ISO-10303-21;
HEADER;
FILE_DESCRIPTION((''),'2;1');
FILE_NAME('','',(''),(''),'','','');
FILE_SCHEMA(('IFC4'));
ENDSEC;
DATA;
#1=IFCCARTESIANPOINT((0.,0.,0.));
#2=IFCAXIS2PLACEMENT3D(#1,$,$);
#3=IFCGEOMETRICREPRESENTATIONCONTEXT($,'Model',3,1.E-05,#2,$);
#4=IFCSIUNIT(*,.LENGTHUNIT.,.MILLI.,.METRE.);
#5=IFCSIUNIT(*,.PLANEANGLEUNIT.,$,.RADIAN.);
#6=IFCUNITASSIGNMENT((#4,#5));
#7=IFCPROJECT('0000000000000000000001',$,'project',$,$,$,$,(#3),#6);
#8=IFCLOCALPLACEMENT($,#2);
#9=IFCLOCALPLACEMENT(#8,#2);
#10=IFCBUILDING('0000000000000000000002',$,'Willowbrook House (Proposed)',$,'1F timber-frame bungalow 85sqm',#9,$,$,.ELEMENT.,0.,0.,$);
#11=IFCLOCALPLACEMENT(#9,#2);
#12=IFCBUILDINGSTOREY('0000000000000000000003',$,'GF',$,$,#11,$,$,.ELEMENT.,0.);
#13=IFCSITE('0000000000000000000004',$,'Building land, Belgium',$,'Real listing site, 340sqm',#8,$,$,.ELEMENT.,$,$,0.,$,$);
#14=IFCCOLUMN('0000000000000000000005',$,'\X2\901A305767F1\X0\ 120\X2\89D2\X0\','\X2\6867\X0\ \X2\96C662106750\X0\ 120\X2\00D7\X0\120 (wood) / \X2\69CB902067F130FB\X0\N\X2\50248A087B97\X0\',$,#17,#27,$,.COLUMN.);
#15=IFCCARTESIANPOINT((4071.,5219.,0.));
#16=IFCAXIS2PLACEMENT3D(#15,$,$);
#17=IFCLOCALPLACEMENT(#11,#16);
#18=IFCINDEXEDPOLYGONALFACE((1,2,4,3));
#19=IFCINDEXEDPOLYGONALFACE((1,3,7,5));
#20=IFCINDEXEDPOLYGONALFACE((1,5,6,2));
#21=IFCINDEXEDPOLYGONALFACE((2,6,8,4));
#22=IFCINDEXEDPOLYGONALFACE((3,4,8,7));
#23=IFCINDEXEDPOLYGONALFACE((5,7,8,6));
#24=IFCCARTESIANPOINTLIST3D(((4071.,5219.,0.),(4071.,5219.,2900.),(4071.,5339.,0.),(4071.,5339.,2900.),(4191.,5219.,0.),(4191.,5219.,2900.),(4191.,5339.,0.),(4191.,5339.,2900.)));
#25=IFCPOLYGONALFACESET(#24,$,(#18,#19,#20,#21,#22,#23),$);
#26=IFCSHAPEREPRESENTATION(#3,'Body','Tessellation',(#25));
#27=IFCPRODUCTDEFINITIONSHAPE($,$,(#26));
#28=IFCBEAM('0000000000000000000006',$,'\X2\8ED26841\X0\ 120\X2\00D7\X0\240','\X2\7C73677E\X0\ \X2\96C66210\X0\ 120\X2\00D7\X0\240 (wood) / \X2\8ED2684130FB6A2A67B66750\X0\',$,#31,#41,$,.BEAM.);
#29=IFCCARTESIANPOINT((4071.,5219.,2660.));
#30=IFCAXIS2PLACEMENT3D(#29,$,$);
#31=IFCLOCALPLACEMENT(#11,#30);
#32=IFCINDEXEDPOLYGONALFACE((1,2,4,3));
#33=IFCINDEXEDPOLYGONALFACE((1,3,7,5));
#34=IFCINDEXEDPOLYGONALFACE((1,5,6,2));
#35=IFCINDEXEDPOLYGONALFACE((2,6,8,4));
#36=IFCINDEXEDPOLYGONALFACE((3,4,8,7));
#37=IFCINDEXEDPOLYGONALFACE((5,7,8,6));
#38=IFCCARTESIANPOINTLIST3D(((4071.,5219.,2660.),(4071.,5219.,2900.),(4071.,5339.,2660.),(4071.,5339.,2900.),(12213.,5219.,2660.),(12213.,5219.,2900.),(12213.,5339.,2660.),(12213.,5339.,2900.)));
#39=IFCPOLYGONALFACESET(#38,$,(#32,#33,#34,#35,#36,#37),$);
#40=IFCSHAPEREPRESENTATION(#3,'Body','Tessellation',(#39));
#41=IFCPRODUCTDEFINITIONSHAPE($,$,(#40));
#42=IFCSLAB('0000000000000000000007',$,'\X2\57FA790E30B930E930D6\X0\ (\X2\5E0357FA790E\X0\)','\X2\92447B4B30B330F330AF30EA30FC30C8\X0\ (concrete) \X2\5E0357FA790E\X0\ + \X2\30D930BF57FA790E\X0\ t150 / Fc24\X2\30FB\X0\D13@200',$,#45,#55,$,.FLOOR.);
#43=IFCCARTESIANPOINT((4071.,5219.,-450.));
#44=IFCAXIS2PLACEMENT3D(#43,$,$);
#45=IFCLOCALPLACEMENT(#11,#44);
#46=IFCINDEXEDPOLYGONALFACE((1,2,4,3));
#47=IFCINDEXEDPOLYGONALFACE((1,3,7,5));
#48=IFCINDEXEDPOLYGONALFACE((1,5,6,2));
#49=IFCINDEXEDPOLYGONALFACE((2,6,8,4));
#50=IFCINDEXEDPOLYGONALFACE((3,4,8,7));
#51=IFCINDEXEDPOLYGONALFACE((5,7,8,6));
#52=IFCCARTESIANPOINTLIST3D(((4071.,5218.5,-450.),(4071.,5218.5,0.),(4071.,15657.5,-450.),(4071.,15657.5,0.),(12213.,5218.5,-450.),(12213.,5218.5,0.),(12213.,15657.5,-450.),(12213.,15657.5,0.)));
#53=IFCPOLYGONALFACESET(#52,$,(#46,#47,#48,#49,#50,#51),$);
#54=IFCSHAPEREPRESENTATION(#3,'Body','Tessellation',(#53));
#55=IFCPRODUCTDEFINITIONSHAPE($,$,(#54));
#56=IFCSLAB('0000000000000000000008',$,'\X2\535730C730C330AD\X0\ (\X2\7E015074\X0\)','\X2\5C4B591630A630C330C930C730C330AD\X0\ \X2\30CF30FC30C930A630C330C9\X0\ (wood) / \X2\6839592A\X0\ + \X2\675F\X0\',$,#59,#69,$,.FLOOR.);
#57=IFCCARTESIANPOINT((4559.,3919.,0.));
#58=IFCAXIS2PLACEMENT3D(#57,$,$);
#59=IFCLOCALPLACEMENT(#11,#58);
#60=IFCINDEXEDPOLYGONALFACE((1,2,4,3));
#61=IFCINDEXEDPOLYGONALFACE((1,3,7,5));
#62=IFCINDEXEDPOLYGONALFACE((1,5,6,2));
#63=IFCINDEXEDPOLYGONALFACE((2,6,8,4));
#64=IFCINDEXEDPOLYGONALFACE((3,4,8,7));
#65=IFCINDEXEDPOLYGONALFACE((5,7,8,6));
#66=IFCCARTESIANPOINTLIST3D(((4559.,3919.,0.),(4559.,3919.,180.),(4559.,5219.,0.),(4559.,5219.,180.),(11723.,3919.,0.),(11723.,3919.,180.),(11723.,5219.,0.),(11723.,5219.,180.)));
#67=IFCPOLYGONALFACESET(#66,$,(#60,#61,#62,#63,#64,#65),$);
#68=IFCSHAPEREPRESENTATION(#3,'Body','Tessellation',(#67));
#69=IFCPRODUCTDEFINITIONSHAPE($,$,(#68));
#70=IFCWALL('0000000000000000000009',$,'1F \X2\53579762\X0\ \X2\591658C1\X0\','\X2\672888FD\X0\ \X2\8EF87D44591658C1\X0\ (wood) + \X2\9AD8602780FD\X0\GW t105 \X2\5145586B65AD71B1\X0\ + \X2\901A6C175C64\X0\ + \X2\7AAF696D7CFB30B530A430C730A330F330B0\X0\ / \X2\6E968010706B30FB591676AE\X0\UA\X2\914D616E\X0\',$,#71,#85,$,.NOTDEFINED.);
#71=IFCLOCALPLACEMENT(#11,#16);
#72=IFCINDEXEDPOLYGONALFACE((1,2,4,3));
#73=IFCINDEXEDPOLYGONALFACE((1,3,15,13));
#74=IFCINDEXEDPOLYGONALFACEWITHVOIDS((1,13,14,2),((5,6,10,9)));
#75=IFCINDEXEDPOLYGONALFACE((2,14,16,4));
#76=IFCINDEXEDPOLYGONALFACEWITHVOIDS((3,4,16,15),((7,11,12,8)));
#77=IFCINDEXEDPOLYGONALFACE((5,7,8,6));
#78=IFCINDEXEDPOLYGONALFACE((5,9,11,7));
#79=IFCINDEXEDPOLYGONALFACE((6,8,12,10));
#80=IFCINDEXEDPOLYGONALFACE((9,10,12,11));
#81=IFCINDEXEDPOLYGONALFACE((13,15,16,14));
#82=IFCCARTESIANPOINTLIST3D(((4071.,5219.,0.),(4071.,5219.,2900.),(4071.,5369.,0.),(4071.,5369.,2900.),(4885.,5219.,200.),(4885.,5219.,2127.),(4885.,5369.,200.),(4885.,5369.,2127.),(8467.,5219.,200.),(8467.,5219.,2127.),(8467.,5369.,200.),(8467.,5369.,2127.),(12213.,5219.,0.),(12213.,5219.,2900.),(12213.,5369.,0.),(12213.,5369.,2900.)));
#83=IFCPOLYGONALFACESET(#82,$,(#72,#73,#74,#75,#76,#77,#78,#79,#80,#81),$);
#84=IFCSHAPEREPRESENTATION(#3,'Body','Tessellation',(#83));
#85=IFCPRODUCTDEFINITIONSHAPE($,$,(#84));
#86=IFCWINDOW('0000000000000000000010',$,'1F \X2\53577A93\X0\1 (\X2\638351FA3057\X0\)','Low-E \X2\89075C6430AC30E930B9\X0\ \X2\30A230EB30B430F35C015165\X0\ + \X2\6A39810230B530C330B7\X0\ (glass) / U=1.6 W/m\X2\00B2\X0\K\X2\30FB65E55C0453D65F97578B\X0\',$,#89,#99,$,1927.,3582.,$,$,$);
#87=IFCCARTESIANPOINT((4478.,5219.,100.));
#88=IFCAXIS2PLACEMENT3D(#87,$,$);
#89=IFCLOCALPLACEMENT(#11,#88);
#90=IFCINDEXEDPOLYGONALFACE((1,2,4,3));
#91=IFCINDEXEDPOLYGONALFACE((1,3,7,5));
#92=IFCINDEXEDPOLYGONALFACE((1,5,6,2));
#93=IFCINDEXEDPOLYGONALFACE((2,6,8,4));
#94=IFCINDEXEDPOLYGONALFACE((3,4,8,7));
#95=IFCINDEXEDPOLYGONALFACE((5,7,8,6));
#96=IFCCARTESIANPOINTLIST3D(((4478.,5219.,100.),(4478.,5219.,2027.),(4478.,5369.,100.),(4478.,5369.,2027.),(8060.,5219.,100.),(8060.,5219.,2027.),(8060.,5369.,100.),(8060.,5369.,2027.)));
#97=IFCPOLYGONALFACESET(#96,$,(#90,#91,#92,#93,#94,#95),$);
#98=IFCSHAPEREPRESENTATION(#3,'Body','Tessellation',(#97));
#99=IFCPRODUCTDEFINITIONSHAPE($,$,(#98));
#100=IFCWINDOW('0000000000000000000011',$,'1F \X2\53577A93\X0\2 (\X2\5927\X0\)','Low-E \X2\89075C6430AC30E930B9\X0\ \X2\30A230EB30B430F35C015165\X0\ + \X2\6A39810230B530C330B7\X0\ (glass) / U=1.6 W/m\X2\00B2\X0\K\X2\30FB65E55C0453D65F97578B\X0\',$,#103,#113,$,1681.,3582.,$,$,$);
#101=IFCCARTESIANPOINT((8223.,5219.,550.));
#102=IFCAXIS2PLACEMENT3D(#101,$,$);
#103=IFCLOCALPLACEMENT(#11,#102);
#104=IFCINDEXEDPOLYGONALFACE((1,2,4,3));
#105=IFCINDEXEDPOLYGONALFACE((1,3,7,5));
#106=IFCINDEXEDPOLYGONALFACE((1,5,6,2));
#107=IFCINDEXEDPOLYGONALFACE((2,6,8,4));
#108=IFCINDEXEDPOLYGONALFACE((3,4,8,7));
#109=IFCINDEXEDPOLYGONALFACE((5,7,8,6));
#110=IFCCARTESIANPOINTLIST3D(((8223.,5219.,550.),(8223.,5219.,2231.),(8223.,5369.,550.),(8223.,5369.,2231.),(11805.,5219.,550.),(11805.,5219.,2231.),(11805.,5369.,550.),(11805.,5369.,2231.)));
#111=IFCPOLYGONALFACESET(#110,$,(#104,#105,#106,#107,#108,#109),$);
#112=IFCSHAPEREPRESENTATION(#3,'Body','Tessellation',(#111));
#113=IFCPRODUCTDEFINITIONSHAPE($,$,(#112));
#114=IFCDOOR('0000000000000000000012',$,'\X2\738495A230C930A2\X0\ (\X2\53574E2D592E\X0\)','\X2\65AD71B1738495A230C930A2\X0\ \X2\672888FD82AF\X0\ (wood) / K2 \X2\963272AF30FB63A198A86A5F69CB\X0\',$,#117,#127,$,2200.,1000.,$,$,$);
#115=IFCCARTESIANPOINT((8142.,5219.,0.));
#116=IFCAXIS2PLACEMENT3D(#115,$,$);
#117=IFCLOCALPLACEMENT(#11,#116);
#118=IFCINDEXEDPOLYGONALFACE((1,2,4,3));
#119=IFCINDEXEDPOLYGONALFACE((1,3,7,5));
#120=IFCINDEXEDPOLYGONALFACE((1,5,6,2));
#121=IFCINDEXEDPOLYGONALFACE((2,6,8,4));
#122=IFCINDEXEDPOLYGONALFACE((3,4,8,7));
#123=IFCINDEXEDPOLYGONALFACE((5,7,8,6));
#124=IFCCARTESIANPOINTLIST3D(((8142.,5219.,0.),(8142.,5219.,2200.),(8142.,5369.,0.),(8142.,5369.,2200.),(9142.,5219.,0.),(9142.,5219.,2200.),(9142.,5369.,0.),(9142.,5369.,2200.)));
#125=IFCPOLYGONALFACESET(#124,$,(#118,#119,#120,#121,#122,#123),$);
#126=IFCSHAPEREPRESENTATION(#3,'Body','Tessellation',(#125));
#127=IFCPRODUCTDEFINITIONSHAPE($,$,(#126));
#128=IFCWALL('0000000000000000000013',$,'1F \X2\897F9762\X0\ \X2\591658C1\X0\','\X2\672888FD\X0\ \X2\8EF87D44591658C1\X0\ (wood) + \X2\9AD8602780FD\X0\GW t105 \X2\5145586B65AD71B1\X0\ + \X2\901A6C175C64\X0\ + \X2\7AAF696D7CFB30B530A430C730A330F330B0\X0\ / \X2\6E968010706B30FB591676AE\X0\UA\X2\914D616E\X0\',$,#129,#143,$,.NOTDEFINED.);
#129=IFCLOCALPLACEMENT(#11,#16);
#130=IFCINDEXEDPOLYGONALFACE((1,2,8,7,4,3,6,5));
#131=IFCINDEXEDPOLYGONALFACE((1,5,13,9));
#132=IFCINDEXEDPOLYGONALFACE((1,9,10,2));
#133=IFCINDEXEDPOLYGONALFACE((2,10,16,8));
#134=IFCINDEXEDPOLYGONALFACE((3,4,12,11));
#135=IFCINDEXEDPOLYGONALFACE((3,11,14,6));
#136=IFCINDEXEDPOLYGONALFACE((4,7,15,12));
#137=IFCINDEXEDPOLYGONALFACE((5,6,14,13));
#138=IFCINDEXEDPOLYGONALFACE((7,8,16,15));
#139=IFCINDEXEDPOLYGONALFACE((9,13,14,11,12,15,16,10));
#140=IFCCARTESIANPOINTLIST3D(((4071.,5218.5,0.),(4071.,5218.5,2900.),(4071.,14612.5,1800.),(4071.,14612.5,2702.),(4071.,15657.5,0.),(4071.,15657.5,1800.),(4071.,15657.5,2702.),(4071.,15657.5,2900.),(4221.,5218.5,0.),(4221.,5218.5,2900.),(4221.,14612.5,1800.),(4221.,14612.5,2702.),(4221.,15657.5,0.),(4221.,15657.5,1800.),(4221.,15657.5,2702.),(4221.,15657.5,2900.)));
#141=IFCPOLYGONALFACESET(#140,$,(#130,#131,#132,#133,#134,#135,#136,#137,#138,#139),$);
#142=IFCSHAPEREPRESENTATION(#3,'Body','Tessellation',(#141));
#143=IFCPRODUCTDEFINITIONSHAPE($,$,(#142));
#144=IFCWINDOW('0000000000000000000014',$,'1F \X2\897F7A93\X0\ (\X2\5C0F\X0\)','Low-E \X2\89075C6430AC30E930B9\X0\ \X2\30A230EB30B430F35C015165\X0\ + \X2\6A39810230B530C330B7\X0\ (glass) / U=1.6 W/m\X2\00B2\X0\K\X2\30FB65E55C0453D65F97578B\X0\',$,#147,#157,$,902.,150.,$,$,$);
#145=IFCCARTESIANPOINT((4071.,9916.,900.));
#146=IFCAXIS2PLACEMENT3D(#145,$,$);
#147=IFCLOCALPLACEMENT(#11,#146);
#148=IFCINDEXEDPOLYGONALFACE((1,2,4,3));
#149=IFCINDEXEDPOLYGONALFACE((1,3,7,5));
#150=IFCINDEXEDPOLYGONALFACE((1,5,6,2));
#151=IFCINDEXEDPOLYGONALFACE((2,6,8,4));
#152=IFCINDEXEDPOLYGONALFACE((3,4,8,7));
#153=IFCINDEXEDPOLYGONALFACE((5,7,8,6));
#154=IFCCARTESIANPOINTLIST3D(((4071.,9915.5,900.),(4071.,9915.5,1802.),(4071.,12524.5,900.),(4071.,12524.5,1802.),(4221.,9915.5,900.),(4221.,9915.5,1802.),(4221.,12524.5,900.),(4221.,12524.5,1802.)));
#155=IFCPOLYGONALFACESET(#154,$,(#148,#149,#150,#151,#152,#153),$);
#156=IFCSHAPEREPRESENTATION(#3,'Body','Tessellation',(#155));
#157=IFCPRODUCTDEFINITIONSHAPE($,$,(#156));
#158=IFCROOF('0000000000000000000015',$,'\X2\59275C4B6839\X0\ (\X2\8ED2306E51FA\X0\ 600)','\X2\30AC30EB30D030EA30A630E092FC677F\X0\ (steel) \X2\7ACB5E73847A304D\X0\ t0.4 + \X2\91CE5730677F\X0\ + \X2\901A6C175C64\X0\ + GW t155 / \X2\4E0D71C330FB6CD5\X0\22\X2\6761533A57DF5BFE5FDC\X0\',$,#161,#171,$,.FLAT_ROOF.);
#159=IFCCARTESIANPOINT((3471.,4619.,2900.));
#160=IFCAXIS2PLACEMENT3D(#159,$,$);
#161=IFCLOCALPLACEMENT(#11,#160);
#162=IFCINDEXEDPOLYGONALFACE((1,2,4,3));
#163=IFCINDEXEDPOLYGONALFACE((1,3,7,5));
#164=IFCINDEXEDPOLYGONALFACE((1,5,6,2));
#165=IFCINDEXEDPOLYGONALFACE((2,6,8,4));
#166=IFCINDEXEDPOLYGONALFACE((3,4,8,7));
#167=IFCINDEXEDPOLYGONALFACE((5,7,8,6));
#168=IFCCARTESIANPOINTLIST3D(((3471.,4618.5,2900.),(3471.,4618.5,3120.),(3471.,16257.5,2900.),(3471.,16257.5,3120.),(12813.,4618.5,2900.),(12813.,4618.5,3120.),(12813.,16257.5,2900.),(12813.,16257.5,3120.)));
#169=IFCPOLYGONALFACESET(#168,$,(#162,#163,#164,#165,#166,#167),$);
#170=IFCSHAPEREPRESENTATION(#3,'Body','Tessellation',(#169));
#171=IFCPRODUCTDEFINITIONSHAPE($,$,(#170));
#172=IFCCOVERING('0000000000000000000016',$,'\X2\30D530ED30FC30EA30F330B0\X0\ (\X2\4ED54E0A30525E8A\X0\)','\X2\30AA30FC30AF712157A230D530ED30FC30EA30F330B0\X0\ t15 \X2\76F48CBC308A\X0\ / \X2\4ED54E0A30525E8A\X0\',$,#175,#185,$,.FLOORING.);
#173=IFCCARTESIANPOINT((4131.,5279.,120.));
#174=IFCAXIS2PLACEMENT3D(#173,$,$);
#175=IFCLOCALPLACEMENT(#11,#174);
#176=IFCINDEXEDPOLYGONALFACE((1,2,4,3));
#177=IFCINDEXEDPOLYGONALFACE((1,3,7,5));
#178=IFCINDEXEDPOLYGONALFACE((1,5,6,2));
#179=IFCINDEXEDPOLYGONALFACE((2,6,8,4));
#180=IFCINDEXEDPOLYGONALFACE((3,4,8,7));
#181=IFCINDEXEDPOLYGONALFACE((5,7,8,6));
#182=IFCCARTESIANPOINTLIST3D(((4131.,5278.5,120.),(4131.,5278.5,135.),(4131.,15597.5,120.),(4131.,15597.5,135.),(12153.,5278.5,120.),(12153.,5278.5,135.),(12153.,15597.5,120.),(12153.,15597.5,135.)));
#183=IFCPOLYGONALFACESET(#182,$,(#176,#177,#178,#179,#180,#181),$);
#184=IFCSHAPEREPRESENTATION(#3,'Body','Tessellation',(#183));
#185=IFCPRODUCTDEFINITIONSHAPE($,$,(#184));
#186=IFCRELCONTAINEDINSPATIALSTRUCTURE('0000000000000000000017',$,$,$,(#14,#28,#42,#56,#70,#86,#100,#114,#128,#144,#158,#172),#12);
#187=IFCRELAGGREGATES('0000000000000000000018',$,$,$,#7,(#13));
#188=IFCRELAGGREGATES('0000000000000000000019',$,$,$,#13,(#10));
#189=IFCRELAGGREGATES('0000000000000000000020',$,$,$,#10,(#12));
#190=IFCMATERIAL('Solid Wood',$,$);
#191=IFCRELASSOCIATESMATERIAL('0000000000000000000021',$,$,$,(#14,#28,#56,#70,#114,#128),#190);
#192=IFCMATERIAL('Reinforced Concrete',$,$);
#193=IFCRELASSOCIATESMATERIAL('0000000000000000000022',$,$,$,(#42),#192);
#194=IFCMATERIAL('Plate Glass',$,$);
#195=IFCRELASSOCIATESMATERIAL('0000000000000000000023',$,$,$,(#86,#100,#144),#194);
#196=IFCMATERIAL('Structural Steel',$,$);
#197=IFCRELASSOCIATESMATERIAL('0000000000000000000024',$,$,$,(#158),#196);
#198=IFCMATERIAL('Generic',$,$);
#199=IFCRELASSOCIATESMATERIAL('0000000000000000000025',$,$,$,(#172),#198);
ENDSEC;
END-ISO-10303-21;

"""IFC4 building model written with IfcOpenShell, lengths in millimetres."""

from ifc_helpers import new_model, si_unit, frame, frame_2d, origin, place, context, project, spatial, rectangle, extrude, material, element, fill, save


model = new_model("IFC4")

# Units and contexts
model_context = context("Model", 3, precision=1e-05, world=origin())
ifc_project = project(units=[si_unit("LENGTHUNIT", "METRE", prefix="MILLI"), si_unit("PLANEANGLEUNIT", "RADIAN")], contexts=[model_context])

# Site, building, storey
site_placement = place(None, origin())
site = spatial("IfcSite", under=ifc_project, at=site_placement, Name="Building land, Belgium", ObjectType="Real listing site, 340sqm", CompositionType="ELEMENT", RefElevation=0.0)
building_placement = place(site_placement, origin())
building = spatial("IfcBuilding", under=site, at=building_placement, Name="Willowbrook House (Proposed)", ObjectType="1F timber-frame bungalow 85sqm", CompositionType="ELEMENT", ElevationOfRefHeight=0.0, ElevationOfTerrain=0.0)
storey_placement = place(building_placement, origin())
storey = spatial("IfcBuildingStorey", under=building, at=storey_placement, Name="GF", CompositionType="ELEMENT", Elevation=0.0)

# Column
ifc_material_1 = material(Name="Solid Wood")
column_1_placement = place(storey_placement, frame((4071.0, 5219.0, 0.0)))
element("IfcColumn", 1, at=column_1_placement, inside=storey, material=ifc_material_1, Name="通し柱 120角", Description="桧 集成材 120×120 (wood) / 構造柱・N値計算", PredefinedType="COLUMN", context=model_context, shape_type="SweptSolid", body=[
    extrude(rectangle(XDim=120.0, YDim=120.0, at=frame_2d((60.0, 60.0))), frame((4071.0, 5219.0, 0.0)), (0.0, 0.0, 1.0), 2900.0),
])

# Beam
beam_1_placement = place(storey_placement, frame((4071.0, 5219.0, 2660.0)))
element("IfcBeam", 2, at=beam_1_placement, inside=storey, material=ifc_material_1, Name="軒桁 120×240", Description="米松 集成 120×240 (wood) / 軒桁・横架材", PredefinedType="BEAM", context=model_context, shape_type="SweptSolid", body=[
    extrude(rectangle(XDim=8142.0, YDim=120.0, at=frame_2d((4071.0, 60.0))), frame((4071.0, 5219.0, 2660.0)), (0.0, 0.0, 1.0), 240.0),
])

# Slabs
ifc_material_2 = material(Name="Reinforced Concrete")
slab_1_placement = place(storey_placement, frame((4071.0, 5219.0, -450.0)))
element("IfcSlab", 3, at=slab_1_placement, inside=storey, material=ifc_material_2, Name="基礎スラブ (布基礎)", Description="鉄筋コンクリート (concrete) 布基礎 + ベタ基礎 t150 / Fc24・D13@200", PredefinedType="FLOOR", context=model_context, shape_type="SweptSolid", body=[
    extrude(rectangle(XDim=8142.0, YDim=10439.0, at=frame_2d((4071.0, 5219.0))), frame((4071.0, 5219.0, -450.0)), (0.0, 0.0, 1.0), 450.0),
])
slab_2_placement = place(storey_placement, frame((4559.0, 3919.0, 0.0)))
element("IfcSlab", 4, at=slab_2_placement, inside=storey, material=ifc_material_1, Name="南デッキ (縁側)", Description="屋外ウッドデッキ ハードウッド (wood) / 根太 + 束", PredefinedType="FLOOR", context=model_context, shape_type="SweptSolid", body=[
    extrude(rectangle(XDim=7164.0, YDim=1300.0, at=frame_2d((3582.0, 650.0))), frame((4559.0, 3919.0, 0.0)), (0.0, 0.0, 1.0), 180.0),
])

# Wall, openings, windows, door
wall_1_placement = place(storey_placement, frame((4071.0, 5219.0, 0.0)))
wall_1 = element("IfcWall", 5, at=wall_1_placement, inside=storey, material=ifc_material_1, Name="1F 南面 外壁", Description="木製 軸組外壁 (wood) + 高性能GW t105 充填断熱 + 通気層 + 窯業系サイディング / 準耐火・外皮UA配慮", PredefinedType="NOTDEFINED", context=model_context, shape_type="SweptSolid", body=[
    extrude(rectangle(XDim=8142.0, YDim=150.0, at=frame_2d((4071.0, 75.0))), frame((4071.0, 5219.0, 0.0)), (0.0, 0.0, 1.0), 2900.0),
])
opening_1_placement = place(storey_placement, frame((4478.0, 5219.0, 100.0)))
opening_1 = element("IfcOpeningElement", 6, at=opening_1_placement, cuts=wall_1, PredefinedType="NOTDEFINED", context=model_context, shape_type="SweptSolid", body=[
    extrude(rectangle(XDim=3582.0, YDim=150.0, at=frame_2d((1791.0, 75.0))), frame((4478.0, 5219.0, 100.0)), (0.0, 0.0, 1.0), 1927.0),
])
opening_2_placement = place(storey_placement, frame((8223.0, 5219.0, 550.0)))
opening_2 = element("IfcOpeningElement", 7, at=opening_2_placement, cuts=wall_1, PredefinedType="NOTDEFINED", context=model_context, shape_type="SweptSolid", body=[
    extrude(rectangle(XDim=3582.0, YDim=150.0, at=frame_2d((1791.0, 75.0))), frame((8223.0, 5219.0, 550.0)), (0.0, 0.0, 1.0), 1681.0),
])
opening_3_placement = place(storey_placement, frame((8142.0, 5219.0, 0.0)))
opening_3 = element("IfcOpeningElement", 8, at=opening_3_placement, cuts=wall_1, PredefinedType="NOTDEFINED", context=model_context, shape_type="SweptSolid", body=[
    extrude(rectangle(XDim=1000.0, YDim=150.0, at=frame_2d((500.0, 75.0))), frame((8142.0, 5219.0, 0.0)), (0.0, 0.0, 1.0), 2200.0),
])
ifc_material_3 = material(Name="Plate Glass")
window_1_placement = place(storey_placement, frame((4478.0, 5219.0, 100.0)))
window_1 = element("IfcWindow", 9, at=window_1_placement, inside=storey, material=ifc_material_3, Name="1F 南窓1 (掃出し)", Description="Low-E 複層ガラス アルゴン封入 + 樹脂サッシ (glass) / U=1.6 W/m²K・日射取得型", OverallHeight=1927.0, OverallWidth=3582.0, context=model_context, shape_type="SweptSolid", body=[
    extrude(rectangle(XDim=3582.0, YDim=150.0, at=frame_2d((1791.0, 75.0))), frame((4478.0, 5219.0, 100.0)), (0.0, 0.0, 1.0), 1927.0),
])
fill(opening_1, window_1)
window_2_placement = place(storey_placement, frame((8223.0, 5219.0, 550.0)))
window_2 = element("IfcWindow", 10, at=window_2_placement, inside=storey, material=ifc_material_3, Name="1F 南窓2 (大)", Description="Low-E 複層ガラス アルゴン封入 + 樹脂サッシ (glass) / U=1.6 W/m²K・日射取得型", OverallHeight=1681.0, OverallWidth=3582.0, context=model_context, shape_type="SweptSolid", body=[
    extrude(rectangle(XDim=3582.0, YDim=150.0, at=frame_2d((1791.0, 75.0))), frame((8223.0, 5219.0, 550.0)), (0.0, 0.0, 1.0), 1681.0),
])
fill(opening_2, window_2)
door_placement = place(storey_placement, frame((8142.0, 5219.0, 0.0)))
door = element("IfcDoor", 11, at=door_placement, inside=storey, material=ifc_material_1, Name="玄関ドア (南中央)", Description="断熱玄関ドア 木製芯 (wood) / K2 防犯・採風機構", OverallHeight=2200.0, OverallWidth=1000.0, context=model_context, shape_type="SweptSolid", body=[
    extrude(rectangle(XDim=1000.0, YDim=150.0, at=frame_2d((500.0, 75.0))), frame((8142.0, 5219.0, 0.0)), (0.0, 0.0, 1.0), 2200.0),
])
fill(opening_3, door)

# Wall, opening, window
wall_2_placement = place(storey_placement, frame((4071.0, 5219.0, 0.0)))
wall_2 = element("IfcWall", 12, at=wall_2_placement, inside=storey, material=ifc_material_1, Name="1F 西面 外壁", Description="木製 軸組外壁 (wood) + 高性能GW t105 充填断熱 + 通気層 + 窯業系サイディング / 準耐火・外皮UA配慮", PredefinedType="NOTDEFINED", context=model_context, shape_type="SweptSolid", body=[
    extrude(rectangle(XDim=150.0, YDim=10439.0, at=frame_2d((75.0, 5219.0))), frame((4071.0, 5219.0, 0.0)), (0.0, 0.0, 1.0), 2900.0),
])
opening_4_placement = place(storey_placement, frame((4071.0, 9916.0, 900.0)))
opening_4 = element("IfcOpeningElement", 13, at=opening_4_placement, cuts=wall_2, PredefinedType="NOTDEFINED", context=model_context, shape_type="SweptSolid", body=[
    extrude(rectangle(XDim=150.0, YDim=2609.0, at=frame_2d((75.0, 1304.0))), frame((4071.0, 9916.0, 900.0)), (0.0, 0.0, 1.0), 902.0),
])
window_3_placement = place(storey_placement, frame((4071.0, 9916.0, 900.0)))
window_3 = element("IfcWindow", 14, at=window_3_placement, inside=storey, material=ifc_material_3, Name="1F 西窓 (小)", Description="Low-E 複層ガラス アルゴン封入 + 樹脂サッシ (glass) / U=1.6 W/m²K・日射取得型", OverallHeight=902.0, OverallWidth=150.0, context=model_context, shape_type="SweptSolid", body=[
    extrude(rectangle(XDim=150.0, YDim=2609.0, at=frame_2d((75.0, 1304.0))), frame((4071.0, 9916.0, 900.0)), (0.0, 0.0, 1.0), 902.0),
])
fill(opening_4, window_3)

# Roof
ifc_material_4 = material(Name="Structural Steel")
roof_placement = place(storey_placement, frame((3471.0, 4619.0, 2900.0)))
element("IfcRoof", 15, at=roof_placement, inside=storey, material=ifc_material_4, Name="大屋根 (軒の出 600)", Description="ガルバリウム鋼板 (steel) 立平葺き t0.4 + 野地板 + 通気層 + GW t155 / 不燃・法22条区域対応", PredefinedType="FLAT_ROOF", context=model_context, shape_type="SweptSolid", body=[
    extrude(rectangle(XDim=9342.0, YDim=11639.0, at=frame_2d((4671.0, 5819.0))), frame((3471.0, 4619.0, 2900.0)), (0.0, 0.0, 1.0), 220.0),
])

# Covering
ifc_material_5 = material(Name="Generic")
covering_1_placement = place(storey_placement, frame((4131.0, 5279.0, 120.0)))
element("IfcCovering", 16, at=covering_1_placement, inside=storey, material=ifc_material_5, Name="フローリング (仕上げ床)", Description="オーク無垢フローリング t15 直貼り / 仕上げ床", PredefinedType="FLOORING", context=model_context, shape_type="SweptSolid", body=[
    extrude(rectangle(XDim=8022.0, YDim=10319.0, at=frame_2d((4011.0, 5159.0))), frame((4131.0, 5279.0, 120.0)), (0.0, 0.0, 1.0), 15.0),
])

save(model, "model.ifc")
